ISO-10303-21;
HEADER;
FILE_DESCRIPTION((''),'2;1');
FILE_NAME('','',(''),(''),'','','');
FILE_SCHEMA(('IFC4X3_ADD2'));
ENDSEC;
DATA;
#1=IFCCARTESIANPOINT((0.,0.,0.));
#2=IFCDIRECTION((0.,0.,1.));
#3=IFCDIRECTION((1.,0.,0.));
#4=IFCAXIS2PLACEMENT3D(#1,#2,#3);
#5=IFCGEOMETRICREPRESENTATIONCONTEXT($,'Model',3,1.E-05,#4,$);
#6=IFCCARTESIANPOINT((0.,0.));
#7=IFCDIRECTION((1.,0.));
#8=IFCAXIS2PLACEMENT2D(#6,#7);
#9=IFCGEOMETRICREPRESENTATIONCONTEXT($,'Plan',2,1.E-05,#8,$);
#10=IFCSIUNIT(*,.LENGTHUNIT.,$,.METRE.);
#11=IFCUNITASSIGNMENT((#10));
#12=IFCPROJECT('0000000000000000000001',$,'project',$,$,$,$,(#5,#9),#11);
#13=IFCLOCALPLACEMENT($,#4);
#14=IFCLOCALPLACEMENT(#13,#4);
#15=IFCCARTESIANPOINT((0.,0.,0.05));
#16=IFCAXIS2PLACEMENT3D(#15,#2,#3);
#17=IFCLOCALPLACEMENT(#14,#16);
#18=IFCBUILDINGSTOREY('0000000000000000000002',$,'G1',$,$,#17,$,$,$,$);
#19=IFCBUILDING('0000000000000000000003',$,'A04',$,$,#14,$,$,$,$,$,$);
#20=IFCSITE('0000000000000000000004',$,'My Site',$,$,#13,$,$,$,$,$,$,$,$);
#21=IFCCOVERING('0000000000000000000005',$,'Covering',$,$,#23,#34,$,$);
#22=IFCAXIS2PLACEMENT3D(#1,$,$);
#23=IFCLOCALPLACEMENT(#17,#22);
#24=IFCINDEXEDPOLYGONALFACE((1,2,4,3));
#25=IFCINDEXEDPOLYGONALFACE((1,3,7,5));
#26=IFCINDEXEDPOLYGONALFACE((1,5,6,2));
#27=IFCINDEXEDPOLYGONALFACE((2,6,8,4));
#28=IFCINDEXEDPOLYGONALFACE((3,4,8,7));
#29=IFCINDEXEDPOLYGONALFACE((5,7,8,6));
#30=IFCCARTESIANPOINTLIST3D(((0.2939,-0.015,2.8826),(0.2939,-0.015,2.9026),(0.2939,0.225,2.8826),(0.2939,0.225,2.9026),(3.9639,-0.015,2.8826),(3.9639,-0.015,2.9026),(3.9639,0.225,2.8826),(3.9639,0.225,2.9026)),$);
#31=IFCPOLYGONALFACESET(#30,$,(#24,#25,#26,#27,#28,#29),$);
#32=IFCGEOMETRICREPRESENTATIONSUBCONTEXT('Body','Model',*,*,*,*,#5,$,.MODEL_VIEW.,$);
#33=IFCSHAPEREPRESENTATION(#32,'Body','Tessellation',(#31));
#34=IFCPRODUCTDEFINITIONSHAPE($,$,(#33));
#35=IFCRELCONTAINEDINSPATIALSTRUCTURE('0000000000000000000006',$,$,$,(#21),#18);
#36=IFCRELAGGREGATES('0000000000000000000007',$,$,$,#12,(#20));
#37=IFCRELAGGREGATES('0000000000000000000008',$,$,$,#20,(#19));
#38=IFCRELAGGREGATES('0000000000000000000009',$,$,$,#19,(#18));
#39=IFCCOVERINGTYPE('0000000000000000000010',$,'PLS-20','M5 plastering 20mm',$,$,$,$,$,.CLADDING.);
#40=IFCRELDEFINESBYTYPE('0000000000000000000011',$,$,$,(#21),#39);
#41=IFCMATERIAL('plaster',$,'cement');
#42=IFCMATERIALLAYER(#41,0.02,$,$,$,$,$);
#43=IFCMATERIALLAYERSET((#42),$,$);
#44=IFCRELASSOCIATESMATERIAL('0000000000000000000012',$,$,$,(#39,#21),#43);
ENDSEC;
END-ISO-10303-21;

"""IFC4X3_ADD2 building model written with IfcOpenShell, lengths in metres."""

from ifc_helpers import new_model, si_unit, frame, origin_with_axes, origin_2d_with_axis, place, context, subcontext, project, spatial, line, indexed_curve, outline, extrude, material, layer, layer_set, layer_usage, type_object, element, save


model = new_model("IFC4X3_ADD2")

# Units and contexts
model_context = context("Model", 3, precision=1e-05, world=origin_with_axes())
plan_context = context("Plan", 2, precision=1e-05, world=origin_2d_with_axis())
body_context = subcontext(model_context, "Body", "Model", "MODEL_VIEW")
ifc_project = project(units=[si_unit("LENGTHUNIT", "METRE")], contexts=[model_context, plan_context])

# Site, building, storey
site_placement = place(None, origin_with_axes())
site = spatial("IfcSite", under=ifc_project, at=site_placement, Name="My Site")
building_placement = place(site_placement, origin_with_axes())
building = spatial("IfcBuilding", under=site, at=building_placement, Name="A04")
storey_placement = place(building_placement, frame((0.0, 0.0, 0.05), z_axis=(0.0, 0.0, 1.0), x_axis=(1.0, 0.0, 0.0)))
storey = spatial("IfcBuildingStorey", under=building, at=storey_placement, Name="G1")

# Shared definitions
ifc_material_1 = material(Name="plaster", Category="cement")
ifc_layer_1 = layer(ifc_material_1, 0.02)
ifc_layer_set_1 = layer_set([ifc_layer_1])
covering_type = type_object("IfcCoveringType", Name="PLS-20", Description="M5 plastering 20mm", PredefinedType="CLADDING", material=ifc_layer_set_1)

# Covering
ifc_layer_usage_1 = layer_usage(ifc_layer_set_1, "AXIS2", "POSITIVE", 0.0)
covering_1_placement = place(storey_placement, frame((0.2939, -0.015, 2.8826), z_axis=(1.0, 0.0, 0.0), x_axis=(0.0, 1.0, 0.0)))
element("IfcCovering", 1, at=covering_1_placement, inside=storey, type_object=covering_type, material=ifc_layer_usage_1, Name="Covering", context=body_context, shape_type="SweptSolid", body=[
    extrude(outline(indexed_curve([(0.0, 0.0), (0.0, 0.02), (0.24, 0.02), (0.24, 0.0)], segments=[line(1, 2, 3, 4, 1)])), origin_with_axes(), (0.0, 0.0, 1.0), 3.67),
])

save(model, "model.ifc")
